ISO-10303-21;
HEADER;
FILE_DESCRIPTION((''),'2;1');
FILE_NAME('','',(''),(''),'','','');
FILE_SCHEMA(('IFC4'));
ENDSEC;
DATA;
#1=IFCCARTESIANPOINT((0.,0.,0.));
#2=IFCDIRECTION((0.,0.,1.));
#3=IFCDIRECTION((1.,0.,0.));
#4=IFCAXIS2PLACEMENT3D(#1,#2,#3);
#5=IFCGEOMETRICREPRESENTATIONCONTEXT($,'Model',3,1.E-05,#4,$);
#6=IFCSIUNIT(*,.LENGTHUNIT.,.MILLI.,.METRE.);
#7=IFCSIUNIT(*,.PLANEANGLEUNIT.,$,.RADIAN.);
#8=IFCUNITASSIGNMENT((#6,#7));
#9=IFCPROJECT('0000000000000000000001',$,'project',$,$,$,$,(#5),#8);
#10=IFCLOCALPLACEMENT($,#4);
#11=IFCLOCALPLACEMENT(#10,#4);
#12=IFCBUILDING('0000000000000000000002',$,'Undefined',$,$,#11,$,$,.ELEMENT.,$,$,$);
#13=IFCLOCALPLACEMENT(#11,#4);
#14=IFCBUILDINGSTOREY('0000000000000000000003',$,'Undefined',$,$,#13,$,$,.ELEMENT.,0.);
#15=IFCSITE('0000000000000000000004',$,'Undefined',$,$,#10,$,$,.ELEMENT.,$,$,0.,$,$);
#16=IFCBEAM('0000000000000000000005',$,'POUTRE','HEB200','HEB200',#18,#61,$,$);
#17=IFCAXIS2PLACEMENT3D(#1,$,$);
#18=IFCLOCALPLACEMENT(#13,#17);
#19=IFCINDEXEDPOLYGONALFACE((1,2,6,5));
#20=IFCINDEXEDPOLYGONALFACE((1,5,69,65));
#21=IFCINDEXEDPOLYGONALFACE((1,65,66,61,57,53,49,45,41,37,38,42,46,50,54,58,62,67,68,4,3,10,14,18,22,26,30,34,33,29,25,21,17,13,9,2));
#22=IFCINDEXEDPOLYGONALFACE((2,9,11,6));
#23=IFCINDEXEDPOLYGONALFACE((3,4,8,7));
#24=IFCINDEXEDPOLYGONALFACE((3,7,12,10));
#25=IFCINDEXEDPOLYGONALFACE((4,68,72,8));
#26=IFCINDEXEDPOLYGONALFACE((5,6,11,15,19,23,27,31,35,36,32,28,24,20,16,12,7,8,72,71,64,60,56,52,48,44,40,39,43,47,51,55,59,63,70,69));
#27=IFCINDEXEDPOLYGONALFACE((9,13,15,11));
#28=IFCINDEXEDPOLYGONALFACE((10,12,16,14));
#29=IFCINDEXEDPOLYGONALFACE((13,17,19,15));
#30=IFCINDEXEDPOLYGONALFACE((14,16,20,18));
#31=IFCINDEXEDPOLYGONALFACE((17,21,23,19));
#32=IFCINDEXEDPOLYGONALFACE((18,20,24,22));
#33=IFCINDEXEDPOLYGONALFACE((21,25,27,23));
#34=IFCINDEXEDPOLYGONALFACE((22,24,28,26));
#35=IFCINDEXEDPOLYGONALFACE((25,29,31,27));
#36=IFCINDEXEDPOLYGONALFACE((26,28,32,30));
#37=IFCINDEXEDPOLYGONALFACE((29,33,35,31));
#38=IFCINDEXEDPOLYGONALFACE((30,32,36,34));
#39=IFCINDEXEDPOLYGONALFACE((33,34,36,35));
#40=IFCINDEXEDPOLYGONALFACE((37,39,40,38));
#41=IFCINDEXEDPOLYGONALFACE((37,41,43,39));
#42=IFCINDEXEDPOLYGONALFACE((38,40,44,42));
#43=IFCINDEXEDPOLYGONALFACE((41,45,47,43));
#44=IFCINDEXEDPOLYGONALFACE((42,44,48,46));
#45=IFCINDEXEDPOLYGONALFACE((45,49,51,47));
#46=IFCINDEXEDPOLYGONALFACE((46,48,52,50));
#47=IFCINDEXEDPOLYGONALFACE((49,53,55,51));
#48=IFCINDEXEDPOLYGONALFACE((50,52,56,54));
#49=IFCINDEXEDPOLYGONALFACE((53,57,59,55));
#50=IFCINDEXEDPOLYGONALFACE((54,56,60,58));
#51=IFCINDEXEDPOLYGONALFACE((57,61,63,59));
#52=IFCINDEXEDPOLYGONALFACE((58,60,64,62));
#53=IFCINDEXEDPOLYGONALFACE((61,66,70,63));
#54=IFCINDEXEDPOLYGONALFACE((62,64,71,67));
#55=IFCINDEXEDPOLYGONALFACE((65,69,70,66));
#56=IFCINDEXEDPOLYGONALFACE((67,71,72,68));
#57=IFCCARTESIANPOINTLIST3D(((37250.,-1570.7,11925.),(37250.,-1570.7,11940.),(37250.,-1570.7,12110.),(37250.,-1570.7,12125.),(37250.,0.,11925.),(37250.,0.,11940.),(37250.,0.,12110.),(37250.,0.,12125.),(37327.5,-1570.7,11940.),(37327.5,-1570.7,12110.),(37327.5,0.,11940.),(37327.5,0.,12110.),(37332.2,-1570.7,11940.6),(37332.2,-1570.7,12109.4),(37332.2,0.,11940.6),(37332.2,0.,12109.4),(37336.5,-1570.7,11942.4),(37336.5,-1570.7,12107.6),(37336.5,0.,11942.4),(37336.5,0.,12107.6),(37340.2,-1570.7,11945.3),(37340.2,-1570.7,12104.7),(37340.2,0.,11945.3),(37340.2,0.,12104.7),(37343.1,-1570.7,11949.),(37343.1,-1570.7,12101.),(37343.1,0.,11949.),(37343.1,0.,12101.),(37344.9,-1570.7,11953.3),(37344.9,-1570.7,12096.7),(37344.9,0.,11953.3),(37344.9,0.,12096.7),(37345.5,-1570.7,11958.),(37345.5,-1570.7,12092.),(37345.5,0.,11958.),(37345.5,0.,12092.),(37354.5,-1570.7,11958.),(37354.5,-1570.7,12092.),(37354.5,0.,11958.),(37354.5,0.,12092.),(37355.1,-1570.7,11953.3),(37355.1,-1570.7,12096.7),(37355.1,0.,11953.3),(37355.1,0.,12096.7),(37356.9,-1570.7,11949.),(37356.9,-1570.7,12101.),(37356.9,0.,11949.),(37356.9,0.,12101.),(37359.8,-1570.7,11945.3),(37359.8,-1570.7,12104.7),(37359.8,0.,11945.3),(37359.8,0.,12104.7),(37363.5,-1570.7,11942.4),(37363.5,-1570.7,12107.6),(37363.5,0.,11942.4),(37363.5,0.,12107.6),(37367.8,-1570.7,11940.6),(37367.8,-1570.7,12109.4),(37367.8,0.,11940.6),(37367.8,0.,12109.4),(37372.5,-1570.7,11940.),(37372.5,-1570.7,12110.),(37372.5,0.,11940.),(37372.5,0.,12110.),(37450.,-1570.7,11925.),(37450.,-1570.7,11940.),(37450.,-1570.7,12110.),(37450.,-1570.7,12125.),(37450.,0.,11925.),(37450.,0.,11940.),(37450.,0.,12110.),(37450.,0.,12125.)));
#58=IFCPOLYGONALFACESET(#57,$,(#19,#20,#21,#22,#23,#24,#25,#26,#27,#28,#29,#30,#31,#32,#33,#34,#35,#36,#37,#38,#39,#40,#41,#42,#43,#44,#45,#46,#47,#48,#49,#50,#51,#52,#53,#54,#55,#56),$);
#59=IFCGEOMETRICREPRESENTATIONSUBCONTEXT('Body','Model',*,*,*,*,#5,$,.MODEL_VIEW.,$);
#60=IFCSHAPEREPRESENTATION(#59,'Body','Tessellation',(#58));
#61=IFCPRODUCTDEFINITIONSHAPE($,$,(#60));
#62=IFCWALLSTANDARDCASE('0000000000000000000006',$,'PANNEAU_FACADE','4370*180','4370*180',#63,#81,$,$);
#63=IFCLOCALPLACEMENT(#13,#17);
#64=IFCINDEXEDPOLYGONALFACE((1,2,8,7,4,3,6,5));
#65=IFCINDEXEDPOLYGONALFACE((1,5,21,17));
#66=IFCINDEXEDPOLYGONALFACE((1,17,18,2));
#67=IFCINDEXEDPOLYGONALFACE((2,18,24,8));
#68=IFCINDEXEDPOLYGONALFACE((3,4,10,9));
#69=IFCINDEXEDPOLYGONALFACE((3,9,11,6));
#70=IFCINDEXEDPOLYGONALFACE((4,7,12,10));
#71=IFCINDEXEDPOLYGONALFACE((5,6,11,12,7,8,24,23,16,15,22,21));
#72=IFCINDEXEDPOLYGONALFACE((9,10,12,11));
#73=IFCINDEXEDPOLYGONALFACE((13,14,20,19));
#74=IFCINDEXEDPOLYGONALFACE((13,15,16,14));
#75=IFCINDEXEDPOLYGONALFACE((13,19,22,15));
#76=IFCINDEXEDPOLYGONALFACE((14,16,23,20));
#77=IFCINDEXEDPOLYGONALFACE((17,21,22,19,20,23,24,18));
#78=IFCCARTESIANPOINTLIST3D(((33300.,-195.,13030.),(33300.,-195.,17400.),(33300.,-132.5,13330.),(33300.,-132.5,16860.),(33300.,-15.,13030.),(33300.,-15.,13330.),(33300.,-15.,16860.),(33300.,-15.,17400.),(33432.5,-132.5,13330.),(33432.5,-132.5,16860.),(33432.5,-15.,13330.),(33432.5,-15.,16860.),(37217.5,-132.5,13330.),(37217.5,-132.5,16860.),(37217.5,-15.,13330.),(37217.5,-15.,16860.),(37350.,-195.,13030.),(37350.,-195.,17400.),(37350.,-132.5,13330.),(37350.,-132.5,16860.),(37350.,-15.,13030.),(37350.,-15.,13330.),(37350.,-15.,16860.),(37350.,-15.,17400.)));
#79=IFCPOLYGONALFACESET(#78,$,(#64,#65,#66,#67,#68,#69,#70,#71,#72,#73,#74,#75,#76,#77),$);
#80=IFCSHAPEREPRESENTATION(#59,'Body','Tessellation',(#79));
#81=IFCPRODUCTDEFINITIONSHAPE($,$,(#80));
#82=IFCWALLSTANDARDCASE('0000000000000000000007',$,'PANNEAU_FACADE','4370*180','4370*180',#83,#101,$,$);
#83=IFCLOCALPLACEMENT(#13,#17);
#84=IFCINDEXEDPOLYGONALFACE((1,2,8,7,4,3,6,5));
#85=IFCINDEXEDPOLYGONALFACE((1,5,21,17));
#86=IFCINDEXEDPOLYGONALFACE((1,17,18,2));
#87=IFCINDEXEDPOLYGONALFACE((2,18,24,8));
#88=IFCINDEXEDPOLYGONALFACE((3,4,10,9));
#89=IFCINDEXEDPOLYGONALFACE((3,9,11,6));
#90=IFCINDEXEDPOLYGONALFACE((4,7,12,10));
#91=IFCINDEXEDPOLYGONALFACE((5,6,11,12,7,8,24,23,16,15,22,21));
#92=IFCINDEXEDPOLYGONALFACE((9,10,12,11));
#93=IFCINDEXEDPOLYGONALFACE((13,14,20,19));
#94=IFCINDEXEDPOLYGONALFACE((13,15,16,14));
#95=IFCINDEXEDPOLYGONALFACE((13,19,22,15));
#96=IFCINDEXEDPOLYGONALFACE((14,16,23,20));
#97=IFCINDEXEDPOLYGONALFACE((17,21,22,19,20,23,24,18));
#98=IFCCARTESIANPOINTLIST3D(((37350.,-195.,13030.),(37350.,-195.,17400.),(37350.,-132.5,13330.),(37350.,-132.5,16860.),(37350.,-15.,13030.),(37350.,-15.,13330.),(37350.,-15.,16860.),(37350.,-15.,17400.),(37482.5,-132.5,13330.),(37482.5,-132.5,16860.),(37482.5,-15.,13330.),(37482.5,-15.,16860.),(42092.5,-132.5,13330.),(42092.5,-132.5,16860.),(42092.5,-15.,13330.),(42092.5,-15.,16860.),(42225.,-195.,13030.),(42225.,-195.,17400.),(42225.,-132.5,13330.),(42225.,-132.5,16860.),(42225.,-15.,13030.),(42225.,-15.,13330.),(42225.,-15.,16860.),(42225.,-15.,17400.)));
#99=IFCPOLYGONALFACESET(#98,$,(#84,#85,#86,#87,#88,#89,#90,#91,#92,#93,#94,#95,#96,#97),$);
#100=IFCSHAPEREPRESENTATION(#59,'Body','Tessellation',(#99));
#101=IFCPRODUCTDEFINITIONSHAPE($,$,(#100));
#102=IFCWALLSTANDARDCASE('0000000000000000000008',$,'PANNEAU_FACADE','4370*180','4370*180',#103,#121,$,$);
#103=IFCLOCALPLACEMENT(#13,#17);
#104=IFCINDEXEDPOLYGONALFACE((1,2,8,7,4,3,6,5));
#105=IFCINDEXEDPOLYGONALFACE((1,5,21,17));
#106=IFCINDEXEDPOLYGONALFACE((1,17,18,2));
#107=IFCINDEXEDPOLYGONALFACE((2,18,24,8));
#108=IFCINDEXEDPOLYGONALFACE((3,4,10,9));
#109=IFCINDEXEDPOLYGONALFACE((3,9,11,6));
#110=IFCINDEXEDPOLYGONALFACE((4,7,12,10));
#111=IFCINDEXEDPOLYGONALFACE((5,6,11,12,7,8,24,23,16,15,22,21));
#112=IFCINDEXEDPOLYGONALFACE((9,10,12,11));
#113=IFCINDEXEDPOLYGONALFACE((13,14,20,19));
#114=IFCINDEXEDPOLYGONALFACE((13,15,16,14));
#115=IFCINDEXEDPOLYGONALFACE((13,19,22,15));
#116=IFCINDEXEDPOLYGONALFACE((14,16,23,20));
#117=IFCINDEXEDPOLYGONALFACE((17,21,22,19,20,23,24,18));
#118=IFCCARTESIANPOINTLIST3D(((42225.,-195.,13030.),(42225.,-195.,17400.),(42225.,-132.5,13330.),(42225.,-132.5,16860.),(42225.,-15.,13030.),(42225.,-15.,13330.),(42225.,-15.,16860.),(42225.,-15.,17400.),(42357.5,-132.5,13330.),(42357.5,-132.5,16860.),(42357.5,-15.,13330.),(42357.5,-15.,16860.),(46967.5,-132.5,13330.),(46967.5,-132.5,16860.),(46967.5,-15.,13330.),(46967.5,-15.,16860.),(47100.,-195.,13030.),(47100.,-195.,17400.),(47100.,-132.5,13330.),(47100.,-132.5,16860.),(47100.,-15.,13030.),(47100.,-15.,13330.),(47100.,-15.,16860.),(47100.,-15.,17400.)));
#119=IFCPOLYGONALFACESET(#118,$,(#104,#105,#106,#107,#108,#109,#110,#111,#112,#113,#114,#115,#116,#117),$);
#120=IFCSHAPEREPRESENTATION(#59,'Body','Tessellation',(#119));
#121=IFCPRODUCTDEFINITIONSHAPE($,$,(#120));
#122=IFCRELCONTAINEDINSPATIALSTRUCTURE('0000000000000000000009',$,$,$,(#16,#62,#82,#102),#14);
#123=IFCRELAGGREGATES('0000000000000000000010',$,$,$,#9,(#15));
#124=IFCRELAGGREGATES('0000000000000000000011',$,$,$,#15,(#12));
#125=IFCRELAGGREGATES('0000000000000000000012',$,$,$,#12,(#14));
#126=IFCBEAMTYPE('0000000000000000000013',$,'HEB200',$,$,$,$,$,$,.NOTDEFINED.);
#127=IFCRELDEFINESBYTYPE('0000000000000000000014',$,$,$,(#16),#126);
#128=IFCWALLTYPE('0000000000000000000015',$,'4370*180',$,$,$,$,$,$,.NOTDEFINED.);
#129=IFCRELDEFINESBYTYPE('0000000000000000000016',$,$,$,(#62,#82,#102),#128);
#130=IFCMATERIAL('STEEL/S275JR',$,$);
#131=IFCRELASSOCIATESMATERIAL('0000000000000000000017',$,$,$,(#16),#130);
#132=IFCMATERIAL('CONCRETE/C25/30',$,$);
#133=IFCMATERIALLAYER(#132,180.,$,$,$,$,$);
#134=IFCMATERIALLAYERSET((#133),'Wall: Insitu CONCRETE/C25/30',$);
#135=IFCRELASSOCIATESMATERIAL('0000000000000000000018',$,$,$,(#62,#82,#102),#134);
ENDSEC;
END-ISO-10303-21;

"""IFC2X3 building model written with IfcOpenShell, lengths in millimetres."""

from ifc_helpers import new_model, si_unit, frame, frame_2d, origin_with_axes, origin_2d_with_axis, place, context, subcontext, project, spatial, rectangle, i_section, extrude, boolean, material, layer, layer_set, layer_usage, type_object, element, save


model = new_model("IFC2X3")

# Units and contexts
model_context = context("Model", 3, precision=1e-05, world=origin_with_axes())
body_context = subcontext(model_context, "Body", "Model", "MODEL_VIEW")
ifc_project = project(units=[si_unit("LENGTHUNIT", "METRE", prefix="MILLI"), si_unit("PLANEANGLEUNIT", "RADIAN")], contexts=[model_context])

# Site, building, storey
site_placement = place(None, origin_with_axes())
site = spatial("IfcSite", under=ifc_project, at=site_placement, Name="Undefined", CompositionType="ELEMENT", RefElevation=0.0)
building_placement = place(site_placement, origin_with_axes())
building = spatial("IfcBuilding", under=site, at=building_placement, Name="Undefined", CompositionType="ELEMENT")
storey_placement = place(building_placement, origin_with_axes())
storey = spatial("IfcBuildingStorey", under=building, at=storey_placement, Name="Undefined", CompositionType="ELEMENT", Elevation=0.0)

# Shared definitions
ifc_material_1 = material(Name="CONCRETE/C25/30")
ifc_material_2 = material(Name="STEEL/S275JR")

# Beam
beam_type_1 = type_object("IfcBeamType", Name="HEB200", PredefinedType="NOTDEFINED")
beam_1_placement = place(storey_placement, frame((37350.0, 0.0, 12025.0), z_axis=(0.0, 0.0, 1.0), x_axis=(0.0, -1.0, 0.0)))
element("IfcBeam", 1, at=beam_1_placement, inside=storey, type_object=beam_type_1, material=ifc_material_2, Name="POUTRE", Description="HEB200", ObjectType="HEB200", context=body_context, shape_type="SweptSolid", body=[
    extrude(i_section(OverallWidth=200.0, OverallDepth=200.0, WebThickness=9.0, FlangeThickness=15.0, FilletRadius=18.0, at=origin_2d_with_axis()), frame((1570.7, 0.0, 0.0), z_axis=(-1.0, 0.0, 0.0), x_axis=(0.0, -1.0, 0.0)), (0.0, 0.0, 1.0), 1570.7),
])

# Walls
ifc_layer = layer(ifc_material_1, 180.0)
ifc_layer_set = layer_set([ifc_layer], Name="Wall: Insitu CONCRETE/C25/30")
ifc_layer_usage_1 = layer_usage(ifc_layer_set, "AXIS2", "POSITIVE", -90.0)
wall_type_1 = type_object("IfcWallType", Name="4370*180", PredefinedType="NOTDEFINED")
wall_1_placement = place(storey_placement, frame((37350.0, -105.0, 13030.0), z_axis=(0.0, 0.0, 1.0), x_axis=(-1.0, 0.0, 0.0)))
element("IfcWallStandardCase", 2, at=wall_1_placement, inside=storey, type_object=wall_type_1, material=ifc_layer_usage_1, Name="PANNEAU_FACADE", Description="4370*180", ObjectType="4370*180", context=body_context, shape_type="CSG", body=[
    boolean("DIFFERENCE", boolean("DIFFERENCE", extrude(rectangle(XDim=4050.0, YDim=180.0, at=frame_2d((0.0, 2025.0), x_axis=(0.0, -1.0))), frame((0.0, 0.0, 0.0), z_axis=(0.0, 0.0, 1.0), x_axis=(0.0, -1.0, 0.0)), (0.0, 0.0, 1.0), 4370.0), extrude(rectangle(XDim=265.0, YDim=265.0, at=origin_2d_with_axis()), frame((0.0, -105.0, 3830.0), z_axis=(0.0, 0.0, -1.0), x_axis=(1.0, 0.0, 0.0)), (0.0, 0.0, 1.0), 3530.0)), extrude(rectangle(XDim=265.0, YDim=265.0, at=origin_2d_with_axis()), frame((4050.0, -105.0, 3830.0), z_axis=(0.0, 0.0, -1.0), x_axis=(1.0, 0.0, 0.0)), (0.0, 0.0, 1.0), 3530.0)),
])
ifc_layer_usage_2 = layer_usage(ifc_layer_set, "AXIS2", "POSITIVE", -90.0)
wall_2_placement = place(storey_placement, frame((42225.0, -105.0, 13030.0), z_axis=(0.0, 0.0, 1.0), x_axis=(-1.0, 0.0, 0.0)))
element("IfcWallStandardCase", 3, at=wall_2_placement, inside=storey, type_object=wall_type_1, material=ifc_layer_usage_2, Name="PANNEAU_FACADE", Description="4370*180", ObjectType="4370*180", context=body_context, shape_type="CSG", body=[
    boolean("DIFFERENCE", boolean("DIFFERENCE", extrude(rectangle(XDim=4875.0, YDim=180.0, at=frame_2d((0.0, 2437.5), x_axis=(0.0, -1.0))), frame((0.0, 0.0, 0.0), z_axis=(0.0, 0.0, 1.0), x_axis=(0.0, -1.0, 0.0)), (0.0, 0.0, 1.0), 4370.0), extrude(rectangle(XDim=265.0, YDim=265.0, at=origin_2d_with_axis()), frame((0.0, -105.0, 3830.0), z_axis=(0.0, 0.0, -1.0), x_axis=(1.0, 0.0, 0.0)), (0.0, 0.0, 1.0), 3530.0)), extrude(rectangle(XDim=265.0, YDim=265.0, at=origin_2d_with_axis()), frame((4875.0, -105.0, 3830.0), z_axis=(0.0, 0.0, -1.0), x_axis=(1.0, 0.0, 0.0)), (0.0, 0.0, 1.0), 3530.0)),
])
ifc_layer_usage_3 = layer_usage(ifc_layer_set, "AXIS2", "POSITIVE", -90.0)
wall_3_placement = place(storey_placement, frame((47100.0, -105.0, 13030.0), z_axis=(0.0, 0.0, 1.0), x_axis=(-1.0, 0.0, 0.0)))
element("IfcWallStandardCase", 4, at=wall_3_placement, inside=storey, type_object=wall_type_1, material=ifc_layer_usage_3, Name="PANNEAU_FACADE", Description="4370*180", ObjectType="4370*180", context=body_context, shape_type="CSG", body=[
    boolean("DIFFERENCE", boolean("DIFFERENCE", extrude(rectangle(XDim=4875.0, YDim=180.0, at=frame_2d((0.0, 2437.5), x_axis=(0.0, -1.0))), frame((0.0, 0.0, 0.0), z_axis=(0.0, 0.0, 1.0), x_axis=(0.0, -1.0, 0.0)), (0.0, 0.0, 1.0), 4370.0), extrude(rectangle(XDim=265.0, YDim=265.0, at=origin_2d_with_axis()), frame((0.0, -105.0, 3830.0), z_axis=(0.0, 0.0, -1.0), x_axis=(1.0, 0.0, 0.0)), (0.0, 0.0, 1.0), 3530.0)), extrude(rectangle(XDim=265.0, YDim=265.0, at=origin_2d_with_axis()), frame((4875.0, -105.0, 3830.0), z_axis=(0.0, 0.0, -1.0), x_axis=(1.0, 0.0, 0.0)), (0.0, 0.0, 1.0), 3530.0)),
])

save(model, "model.ifc")
